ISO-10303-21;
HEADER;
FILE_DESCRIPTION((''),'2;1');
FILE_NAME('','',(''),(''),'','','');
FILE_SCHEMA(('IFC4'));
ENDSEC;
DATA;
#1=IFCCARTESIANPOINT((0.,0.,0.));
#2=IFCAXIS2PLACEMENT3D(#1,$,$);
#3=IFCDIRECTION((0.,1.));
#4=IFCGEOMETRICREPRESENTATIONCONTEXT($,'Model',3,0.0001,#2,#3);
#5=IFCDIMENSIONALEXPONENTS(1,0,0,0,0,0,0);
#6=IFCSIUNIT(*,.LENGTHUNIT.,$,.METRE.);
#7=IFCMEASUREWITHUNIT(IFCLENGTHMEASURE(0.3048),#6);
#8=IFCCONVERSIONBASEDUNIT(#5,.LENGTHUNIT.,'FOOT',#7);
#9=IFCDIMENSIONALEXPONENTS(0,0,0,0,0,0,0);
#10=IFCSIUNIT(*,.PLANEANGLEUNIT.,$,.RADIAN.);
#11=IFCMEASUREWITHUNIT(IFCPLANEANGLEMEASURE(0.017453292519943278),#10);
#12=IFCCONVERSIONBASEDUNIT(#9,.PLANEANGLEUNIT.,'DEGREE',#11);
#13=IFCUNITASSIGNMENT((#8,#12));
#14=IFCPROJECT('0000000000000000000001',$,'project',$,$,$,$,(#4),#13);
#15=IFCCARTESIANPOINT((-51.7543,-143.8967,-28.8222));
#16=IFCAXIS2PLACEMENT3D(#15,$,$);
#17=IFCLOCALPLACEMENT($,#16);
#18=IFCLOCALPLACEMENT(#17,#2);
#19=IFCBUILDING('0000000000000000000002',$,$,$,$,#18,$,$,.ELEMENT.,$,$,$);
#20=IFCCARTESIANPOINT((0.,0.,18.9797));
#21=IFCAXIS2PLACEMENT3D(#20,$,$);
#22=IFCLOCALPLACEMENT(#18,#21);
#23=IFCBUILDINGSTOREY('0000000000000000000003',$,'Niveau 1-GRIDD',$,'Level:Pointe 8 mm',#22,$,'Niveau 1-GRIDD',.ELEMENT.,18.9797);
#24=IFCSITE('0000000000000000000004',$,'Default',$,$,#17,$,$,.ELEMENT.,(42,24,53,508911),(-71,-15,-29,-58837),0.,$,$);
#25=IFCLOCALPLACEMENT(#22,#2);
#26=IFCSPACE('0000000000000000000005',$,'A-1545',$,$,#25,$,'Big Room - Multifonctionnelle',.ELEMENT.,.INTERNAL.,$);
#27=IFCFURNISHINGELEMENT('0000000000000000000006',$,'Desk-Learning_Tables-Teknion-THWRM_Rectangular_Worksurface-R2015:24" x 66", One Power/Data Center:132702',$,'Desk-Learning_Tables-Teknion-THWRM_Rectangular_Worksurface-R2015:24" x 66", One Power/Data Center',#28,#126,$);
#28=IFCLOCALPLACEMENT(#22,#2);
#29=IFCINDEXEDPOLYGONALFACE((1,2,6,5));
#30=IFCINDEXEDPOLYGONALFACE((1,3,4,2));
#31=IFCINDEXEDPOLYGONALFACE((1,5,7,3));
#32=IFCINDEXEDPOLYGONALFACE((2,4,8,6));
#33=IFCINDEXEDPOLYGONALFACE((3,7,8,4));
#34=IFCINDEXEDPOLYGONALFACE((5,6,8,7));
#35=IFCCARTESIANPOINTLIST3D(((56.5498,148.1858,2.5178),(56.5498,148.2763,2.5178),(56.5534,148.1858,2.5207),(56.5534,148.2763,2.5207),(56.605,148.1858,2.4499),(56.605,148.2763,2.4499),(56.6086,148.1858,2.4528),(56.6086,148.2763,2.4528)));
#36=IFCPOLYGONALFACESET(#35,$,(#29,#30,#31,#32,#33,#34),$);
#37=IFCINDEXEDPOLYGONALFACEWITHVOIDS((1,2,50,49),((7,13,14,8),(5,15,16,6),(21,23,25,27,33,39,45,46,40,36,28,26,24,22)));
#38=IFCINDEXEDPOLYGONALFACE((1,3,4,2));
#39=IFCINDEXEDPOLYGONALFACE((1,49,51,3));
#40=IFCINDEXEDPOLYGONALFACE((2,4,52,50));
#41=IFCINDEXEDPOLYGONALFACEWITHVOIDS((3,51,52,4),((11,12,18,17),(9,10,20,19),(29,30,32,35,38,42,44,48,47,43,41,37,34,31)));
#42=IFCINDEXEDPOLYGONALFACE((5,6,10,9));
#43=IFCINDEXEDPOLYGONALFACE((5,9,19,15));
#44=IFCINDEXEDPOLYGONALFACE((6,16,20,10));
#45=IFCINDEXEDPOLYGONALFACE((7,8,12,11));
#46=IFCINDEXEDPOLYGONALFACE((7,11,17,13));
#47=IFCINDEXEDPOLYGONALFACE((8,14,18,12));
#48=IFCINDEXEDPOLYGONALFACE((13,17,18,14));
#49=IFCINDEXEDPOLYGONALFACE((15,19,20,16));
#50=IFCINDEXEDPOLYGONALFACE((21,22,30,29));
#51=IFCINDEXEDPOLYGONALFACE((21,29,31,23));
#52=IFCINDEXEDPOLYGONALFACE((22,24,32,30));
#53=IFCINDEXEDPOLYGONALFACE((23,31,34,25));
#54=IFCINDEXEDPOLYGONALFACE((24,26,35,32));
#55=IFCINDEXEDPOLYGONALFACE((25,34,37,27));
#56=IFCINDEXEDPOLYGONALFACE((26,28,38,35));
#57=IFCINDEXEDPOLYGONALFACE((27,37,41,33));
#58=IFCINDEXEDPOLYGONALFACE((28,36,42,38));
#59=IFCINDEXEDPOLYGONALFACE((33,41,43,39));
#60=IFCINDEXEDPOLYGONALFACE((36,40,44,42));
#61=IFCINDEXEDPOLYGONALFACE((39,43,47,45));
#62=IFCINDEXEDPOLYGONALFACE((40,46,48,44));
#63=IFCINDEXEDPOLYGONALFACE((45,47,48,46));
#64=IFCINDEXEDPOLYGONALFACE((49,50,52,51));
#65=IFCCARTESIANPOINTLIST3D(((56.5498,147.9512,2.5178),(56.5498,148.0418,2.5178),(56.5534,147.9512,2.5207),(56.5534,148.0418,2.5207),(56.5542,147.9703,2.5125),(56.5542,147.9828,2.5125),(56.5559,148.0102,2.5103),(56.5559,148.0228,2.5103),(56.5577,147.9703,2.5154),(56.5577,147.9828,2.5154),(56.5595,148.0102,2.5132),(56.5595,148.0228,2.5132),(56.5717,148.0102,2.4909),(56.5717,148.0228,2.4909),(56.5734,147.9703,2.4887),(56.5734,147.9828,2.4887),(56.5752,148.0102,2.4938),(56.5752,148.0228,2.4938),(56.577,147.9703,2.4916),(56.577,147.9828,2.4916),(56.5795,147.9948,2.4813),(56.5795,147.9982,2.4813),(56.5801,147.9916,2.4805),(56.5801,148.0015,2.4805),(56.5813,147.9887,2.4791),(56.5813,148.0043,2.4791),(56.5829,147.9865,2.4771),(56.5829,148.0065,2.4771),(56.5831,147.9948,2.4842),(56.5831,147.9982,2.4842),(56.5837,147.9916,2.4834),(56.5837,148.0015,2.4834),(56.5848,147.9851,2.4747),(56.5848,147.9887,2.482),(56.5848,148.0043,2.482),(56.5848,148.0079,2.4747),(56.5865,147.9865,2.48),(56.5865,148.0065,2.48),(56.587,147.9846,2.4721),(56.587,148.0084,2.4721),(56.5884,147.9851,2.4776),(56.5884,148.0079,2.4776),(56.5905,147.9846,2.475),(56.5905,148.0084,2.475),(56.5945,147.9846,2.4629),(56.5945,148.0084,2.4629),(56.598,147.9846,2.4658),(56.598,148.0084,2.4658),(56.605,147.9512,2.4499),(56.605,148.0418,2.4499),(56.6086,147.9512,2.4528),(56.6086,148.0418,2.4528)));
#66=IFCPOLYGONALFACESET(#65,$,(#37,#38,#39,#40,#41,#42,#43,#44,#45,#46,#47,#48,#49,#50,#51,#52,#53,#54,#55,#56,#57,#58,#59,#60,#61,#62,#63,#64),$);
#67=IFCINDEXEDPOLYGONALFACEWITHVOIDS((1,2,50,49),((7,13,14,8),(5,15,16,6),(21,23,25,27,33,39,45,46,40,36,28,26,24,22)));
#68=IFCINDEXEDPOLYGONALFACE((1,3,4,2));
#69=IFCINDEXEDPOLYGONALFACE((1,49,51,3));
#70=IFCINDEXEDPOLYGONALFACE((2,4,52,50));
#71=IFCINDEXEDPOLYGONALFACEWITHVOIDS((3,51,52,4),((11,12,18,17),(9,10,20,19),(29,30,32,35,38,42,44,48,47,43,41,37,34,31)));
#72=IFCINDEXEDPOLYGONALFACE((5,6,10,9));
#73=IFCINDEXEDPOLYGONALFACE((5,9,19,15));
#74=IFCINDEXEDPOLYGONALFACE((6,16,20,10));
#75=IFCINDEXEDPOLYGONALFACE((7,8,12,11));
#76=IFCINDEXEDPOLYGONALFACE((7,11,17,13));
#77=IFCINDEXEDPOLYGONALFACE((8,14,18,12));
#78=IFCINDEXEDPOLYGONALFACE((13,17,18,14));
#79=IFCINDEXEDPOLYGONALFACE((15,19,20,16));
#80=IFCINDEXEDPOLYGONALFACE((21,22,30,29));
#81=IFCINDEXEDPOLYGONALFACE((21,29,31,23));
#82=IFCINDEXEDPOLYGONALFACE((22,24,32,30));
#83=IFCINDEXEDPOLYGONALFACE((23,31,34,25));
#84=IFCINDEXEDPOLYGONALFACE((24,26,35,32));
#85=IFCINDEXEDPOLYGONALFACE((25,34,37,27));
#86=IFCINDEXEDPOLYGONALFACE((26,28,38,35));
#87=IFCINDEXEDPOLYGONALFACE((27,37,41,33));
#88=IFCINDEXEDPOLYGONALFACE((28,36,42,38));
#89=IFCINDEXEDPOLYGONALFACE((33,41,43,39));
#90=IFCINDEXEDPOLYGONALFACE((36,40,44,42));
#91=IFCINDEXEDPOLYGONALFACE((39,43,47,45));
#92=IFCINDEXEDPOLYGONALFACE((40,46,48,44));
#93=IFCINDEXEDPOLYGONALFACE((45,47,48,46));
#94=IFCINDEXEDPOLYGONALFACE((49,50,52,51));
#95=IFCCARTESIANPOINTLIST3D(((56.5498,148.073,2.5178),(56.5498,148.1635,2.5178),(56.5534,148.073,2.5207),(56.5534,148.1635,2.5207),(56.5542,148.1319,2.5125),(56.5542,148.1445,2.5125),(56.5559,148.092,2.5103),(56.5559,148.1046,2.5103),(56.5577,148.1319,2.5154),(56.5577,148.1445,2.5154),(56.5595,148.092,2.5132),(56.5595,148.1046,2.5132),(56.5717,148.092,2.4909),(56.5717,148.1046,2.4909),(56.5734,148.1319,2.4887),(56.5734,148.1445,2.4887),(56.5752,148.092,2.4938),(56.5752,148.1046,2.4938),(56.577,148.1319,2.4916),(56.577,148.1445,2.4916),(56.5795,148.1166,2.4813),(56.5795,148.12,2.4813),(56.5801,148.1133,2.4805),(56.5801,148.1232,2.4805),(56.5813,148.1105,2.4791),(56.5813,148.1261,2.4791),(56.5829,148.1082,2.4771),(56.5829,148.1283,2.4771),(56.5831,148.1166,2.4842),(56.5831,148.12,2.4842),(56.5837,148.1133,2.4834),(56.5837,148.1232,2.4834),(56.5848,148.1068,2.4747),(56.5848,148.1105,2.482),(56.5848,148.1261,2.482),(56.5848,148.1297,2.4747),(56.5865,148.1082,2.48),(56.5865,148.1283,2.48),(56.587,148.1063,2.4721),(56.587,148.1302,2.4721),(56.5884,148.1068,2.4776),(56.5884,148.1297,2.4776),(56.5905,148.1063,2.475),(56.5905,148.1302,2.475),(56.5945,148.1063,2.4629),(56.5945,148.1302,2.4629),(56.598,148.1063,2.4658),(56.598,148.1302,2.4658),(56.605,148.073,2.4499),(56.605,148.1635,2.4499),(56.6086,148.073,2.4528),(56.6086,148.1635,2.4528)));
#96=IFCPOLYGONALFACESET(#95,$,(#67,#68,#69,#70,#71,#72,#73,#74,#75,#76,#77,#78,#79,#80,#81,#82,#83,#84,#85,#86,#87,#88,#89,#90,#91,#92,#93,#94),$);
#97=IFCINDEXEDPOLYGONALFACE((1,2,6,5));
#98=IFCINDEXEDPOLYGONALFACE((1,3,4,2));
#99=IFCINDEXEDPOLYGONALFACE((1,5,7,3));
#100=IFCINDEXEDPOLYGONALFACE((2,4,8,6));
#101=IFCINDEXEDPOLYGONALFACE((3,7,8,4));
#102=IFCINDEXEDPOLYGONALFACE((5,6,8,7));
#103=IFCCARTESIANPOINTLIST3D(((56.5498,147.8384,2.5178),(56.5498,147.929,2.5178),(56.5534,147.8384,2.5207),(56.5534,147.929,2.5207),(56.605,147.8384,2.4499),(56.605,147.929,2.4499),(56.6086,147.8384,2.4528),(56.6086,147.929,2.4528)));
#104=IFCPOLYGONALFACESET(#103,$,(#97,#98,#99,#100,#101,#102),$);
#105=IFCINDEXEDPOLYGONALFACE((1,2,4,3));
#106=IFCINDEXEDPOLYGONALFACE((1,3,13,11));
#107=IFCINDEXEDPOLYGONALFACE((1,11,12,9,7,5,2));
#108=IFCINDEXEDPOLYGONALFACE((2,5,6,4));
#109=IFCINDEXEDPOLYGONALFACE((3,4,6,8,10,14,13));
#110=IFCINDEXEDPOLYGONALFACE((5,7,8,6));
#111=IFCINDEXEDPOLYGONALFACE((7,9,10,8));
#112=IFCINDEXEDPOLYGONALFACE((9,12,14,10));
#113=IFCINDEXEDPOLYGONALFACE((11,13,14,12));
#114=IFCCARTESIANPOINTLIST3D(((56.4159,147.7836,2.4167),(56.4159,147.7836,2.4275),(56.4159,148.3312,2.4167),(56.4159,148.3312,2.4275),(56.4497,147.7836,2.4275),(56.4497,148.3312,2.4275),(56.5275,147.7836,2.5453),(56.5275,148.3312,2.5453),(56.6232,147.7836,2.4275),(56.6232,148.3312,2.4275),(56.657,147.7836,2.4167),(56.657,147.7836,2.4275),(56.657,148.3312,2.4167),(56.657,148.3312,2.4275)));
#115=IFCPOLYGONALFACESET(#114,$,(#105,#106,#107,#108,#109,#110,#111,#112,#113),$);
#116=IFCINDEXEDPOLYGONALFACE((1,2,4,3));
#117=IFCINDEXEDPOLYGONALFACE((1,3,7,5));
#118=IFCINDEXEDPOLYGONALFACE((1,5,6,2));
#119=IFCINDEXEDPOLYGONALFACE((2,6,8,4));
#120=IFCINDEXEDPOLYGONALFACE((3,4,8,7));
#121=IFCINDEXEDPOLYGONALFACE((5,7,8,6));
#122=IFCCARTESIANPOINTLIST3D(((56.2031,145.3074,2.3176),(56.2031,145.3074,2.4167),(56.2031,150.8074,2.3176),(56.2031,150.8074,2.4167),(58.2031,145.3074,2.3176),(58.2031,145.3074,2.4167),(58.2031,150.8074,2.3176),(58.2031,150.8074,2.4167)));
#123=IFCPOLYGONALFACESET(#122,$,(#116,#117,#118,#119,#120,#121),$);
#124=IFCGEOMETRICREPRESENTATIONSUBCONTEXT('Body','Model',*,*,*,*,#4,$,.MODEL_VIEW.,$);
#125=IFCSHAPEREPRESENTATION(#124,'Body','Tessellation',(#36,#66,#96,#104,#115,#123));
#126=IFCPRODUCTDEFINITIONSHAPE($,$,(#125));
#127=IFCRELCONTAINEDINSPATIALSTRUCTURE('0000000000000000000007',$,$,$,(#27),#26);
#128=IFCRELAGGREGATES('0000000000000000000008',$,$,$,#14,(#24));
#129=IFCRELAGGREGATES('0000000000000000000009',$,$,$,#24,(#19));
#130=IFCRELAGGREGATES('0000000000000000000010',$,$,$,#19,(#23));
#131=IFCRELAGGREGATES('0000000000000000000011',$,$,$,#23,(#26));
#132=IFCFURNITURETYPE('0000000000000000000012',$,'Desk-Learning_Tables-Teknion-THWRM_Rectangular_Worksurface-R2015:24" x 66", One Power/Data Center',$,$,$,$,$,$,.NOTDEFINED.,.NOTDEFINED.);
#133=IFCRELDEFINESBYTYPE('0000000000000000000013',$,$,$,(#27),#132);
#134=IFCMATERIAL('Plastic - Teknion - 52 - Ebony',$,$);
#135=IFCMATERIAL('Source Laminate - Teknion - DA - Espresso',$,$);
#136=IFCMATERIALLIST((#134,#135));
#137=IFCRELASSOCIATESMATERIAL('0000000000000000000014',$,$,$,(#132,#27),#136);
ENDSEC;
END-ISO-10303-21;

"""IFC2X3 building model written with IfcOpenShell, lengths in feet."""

from ifc_helpers import new_model, entity, si_unit, converted_unit, direction, frame, frame_2d, origin, place, context, subcontext, project, spatial, polyline, circle_curve, parameter, trimmed, segment, composite_curve, rectangle, outline, extrude, source, transform, mapped, material, material_list, type_object, type_shapes, element, save


model = new_model("IFC2X3")

# Units and contexts
model_context = context("Model", 3, precision=0.0001, world=origin(), true_north=direction((0.0, 1.0)))
body_context = subcontext(model_context, "Body", "Model", "MODEL_VIEW")
ifc_project = project(units=[converted_unit("LENGTHUNIT", "FOOT", entity("IfcLengthMeasure", 0.3048), si_unit("LENGTHUNIT", "METRE"), dimensions=[1, 0, 0, 0, 0, 0, 0]), converted_unit("PLANEANGLEUNIT", "DEGREE", entity("IfcPlaneAngleMeasure", 0.017453292519943278), si_unit("PLANEANGLEUNIT", "RADIAN"), dimensions=[0, 0, 0, 0, 0, 0, 0])], contexts=[model_context])

# Site, building, storey
site_placement = place(None, frame((-51.7543, -143.8967, -28.8222)))
site = spatial("IfcSite", under=ifc_project, at=site_placement, Name="Default", CompositionType="ELEMENT", RefLatitude=(42, 24, 53, 508911), RefLongitude=(-71, -15, -29, -58837), RefElevation=0.0)
building_placement = place(site_placement, origin())
building = spatial("IfcBuilding", under=site, at=building_placement, CompositionType="ELEMENT")
storey_placement = place(building_placement, frame((0.0, 0.0, 18.9797)))
storey = spatial("IfcBuildingStorey", under=building, at=storey_placement, Name="Niveau 1-GRIDD", ObjectType="Level:Pointe 8 mm", LongName="Niveau 1-GRIDD", CompositionType="ELEMENT", Elevation=18.9797)

# Shared definitions
space_1_placement = place(storey_placement, origin())
space_1 = spatial("IfcSpace", under=storey, at=space_1_placement, Name="A-1545", LongName="Big Room - Multifonctionnelle", CompositionType="ELEMENT", InteriorOrExteriorSpace="INTERNAL")

# Furnishing element
ifc_material_1 = material(Name="Plastic - Teknion - 52 - Ebony")
ifc_material_2 = material(Name="Source Laminate - Teknion - DA - Espresso")
ifc_material_list_1 = material_list([ifc_material_1, ifc_material_2])
furniture_type_1 = type_object("IfcFurnitureType", Name="Desk-Learning_Tables-Teknion-THWRM_Rectangular_Worksurface-R2015:24\" x 66\", One Power/Data Center", AssemblyPlace="NOTDEFINED", material=ifc_material_list_1)
shared_shape_1 = source(origin(), body_context, "Body", "SweptSolid", [
    extrude(rectangle(XDim=0.0875, YDim=0.0046, at=frame_2d((0.0, 0.0), x_axis=(0.0, 1.0))), frame((0.1284, 0.6239, 2.4853), z_axis=(1.0, 0.0, 0.0), x_axis=(0.0, 0.776046, -0.630676)), (0.0, 0.0, 1.0), 0.0906),
    extrude(outline(polyline([(-0.0453, -0.0438), (0.0453, -0.0438), (0.0453, 0.0438), (-0.0453, 0.0438), (-0.0453, -0.0438)]), holes=[polyline([(-0.0262, -0.0063), (-0.0137, -0.0063), (-0.0137, -0.0369), (-0.0262, -0.0369), (-0.0262, -0.0063)]), polyline([(0.0137, -0.0341), (0.0137, -0.0091), (0.0262, -0.0091), (0.0262, -0.0341), (0.0137, -0.0341)]), composite_curve([segment(polyline([(-0.0119, 0.027), (0.0119, 0.027)]), True, "CONTINUOUS"), segment(polyline([(0.0119, 0.027), (0.0119, 0.0151)]), True, "CONTINUOUS"), segment(trimmed(circle_curve(frame_2d((0.0, 0.0151), x_axis=(0.0, -1.0)), 0.0119), [parameter(270.0)], [parameter(90.0)], True, "PARAMETER"), False, "CONTINUOUS"), segment(polyline([(-0.0119, 0.0151), (-0.0119, 0.027)]), True, "CONTINUOUS")], self_intersect=False)]), frame((-0.0609, 0.6221, 2.4867), z_axis=(0.0, 0.776046, -0.630676), x_axis=(1.0, 0.0, 0.0)), (0.0, 0.0, 1.0), 0.0046),
    extrude(outline(polyline([(-0.0438, -0.0453), (0.0438, -0.0453), (0.0438, 0.0453), (-0.0438, 0.0453), (-0.0438, -0.0453)]), holes=[polyline([(-0.0063, -0.0262), (-0.0369, -0.0262), (-0.0369, -0.0137), (-0.0063, -0.0137), (-0.0063, -0.0262)]), polyline([(-0.0341, 0.0137), (-0.0341, 0.0262), (-0.0091, 0.0262), (-0.0091, 0.0137), (-0.0341, 0.0137)]), composite_curve([segment(polyline([(0.027, -0.0119), (0.0151, -0.0119)]), True, "CONTINUOUS"), segment(trimmed(circle_curve(frame_2d((0.0151, 0.0), x_axis=(-1.0, 0.0)), 0.0119), [parameter(270.0)], [parameter(90.0)], True, "PARAMETER"), False, "CONTINUOUS"), segment(polyline([(0.0151, 0.0119), (0.027, 0.0119)]), True, "CONTINUOUS"), segment(polyline([(0.027, 0.0119), (0.027, -0.0119)]), True, "CONTINUOUS")], self_intersect=False)]), frame((0.0609, 0.6221, 2.4867), z_axis=(0.0, 0.776046, -0.630676), x_axis=(0.0, -0.630676, -0.776046)), (0.0, 0.0, 1.0), 0.0046),
    extrude(rectangle(XDim=0.0875, YDim=0.0046, at=frame_2d((0.0, 0.0), x_axis=(0.0, 1.0))), frame((-0.219, 0.6239, 2.4853), z_axis=(1.0, 0.0, 0.0), x_axis=(0.0, 0.776046, -0.630676)), (0.0, 0.0, 1.0), 0.0906),
    extrude(outline(polyline([(-0.0586, -0.0638), (0.0826, -0.0638), (0.0371, 0.0811), (0.0557, 0.1093), (0.0467, 0.1152), (-0.0862, -0.086), (-0.0772, -0.092), (-0.0586, -0.0638)])), frame((-0.2738, 0.6679, 2.4412), z_axis=(1.0, 0.0, 0.0), x_axis=(0.0, -0.551103, 0.834437)), (0.0, 0.0, 1.0), 0.5475),
    extrude(rectangle(XDim=5.5, YDim=2.0, at=frame_2d((0.0, 0.0), x_axis=(1.0, 0.0))), frame((0.0, 0.0, 2.3176), z_axis=(0.0, 0.0, 1.0), x_axis=(-1.0, 0.0, 0.0)), (0.0, 0.0, 1.0), 0.0991),
])
type_shapes(furniture_type_1, [shared_shape_1])
for number, where, z_axis, x_axis, name in (
    (1, (57.2031, 148.0574, 0.0), (0.0, 0.0, 1.0), (0.0, 1.0, 0.0), "Desk-Learning_Tables-Teknion-THWRM_Rectangular_Worksurface-R2015:24\" x 66\", One Power/Data Center:132702"),
):
    element("IfcFurnishingElement", number, at=place(space_1_placement, frame(where, z_axis=z_axis, x_axis=x_axis)), inside=space_1, type_object=furniture_type_1, material=ifc_material_list_1, Name=name, ObjectType="Desk-Learning_Tables-Teknion-THWRM_Rectangular_Worksurface-R2015:24\" x 66\", One Power/Data Center", context=body_context, shape_type="MappedRepresentation", body=[
        mapped(shared_shape_1, transform((0.0, 0.0, 0.0), scale=1.0)),
    ])

save(model, "model.ifc")
